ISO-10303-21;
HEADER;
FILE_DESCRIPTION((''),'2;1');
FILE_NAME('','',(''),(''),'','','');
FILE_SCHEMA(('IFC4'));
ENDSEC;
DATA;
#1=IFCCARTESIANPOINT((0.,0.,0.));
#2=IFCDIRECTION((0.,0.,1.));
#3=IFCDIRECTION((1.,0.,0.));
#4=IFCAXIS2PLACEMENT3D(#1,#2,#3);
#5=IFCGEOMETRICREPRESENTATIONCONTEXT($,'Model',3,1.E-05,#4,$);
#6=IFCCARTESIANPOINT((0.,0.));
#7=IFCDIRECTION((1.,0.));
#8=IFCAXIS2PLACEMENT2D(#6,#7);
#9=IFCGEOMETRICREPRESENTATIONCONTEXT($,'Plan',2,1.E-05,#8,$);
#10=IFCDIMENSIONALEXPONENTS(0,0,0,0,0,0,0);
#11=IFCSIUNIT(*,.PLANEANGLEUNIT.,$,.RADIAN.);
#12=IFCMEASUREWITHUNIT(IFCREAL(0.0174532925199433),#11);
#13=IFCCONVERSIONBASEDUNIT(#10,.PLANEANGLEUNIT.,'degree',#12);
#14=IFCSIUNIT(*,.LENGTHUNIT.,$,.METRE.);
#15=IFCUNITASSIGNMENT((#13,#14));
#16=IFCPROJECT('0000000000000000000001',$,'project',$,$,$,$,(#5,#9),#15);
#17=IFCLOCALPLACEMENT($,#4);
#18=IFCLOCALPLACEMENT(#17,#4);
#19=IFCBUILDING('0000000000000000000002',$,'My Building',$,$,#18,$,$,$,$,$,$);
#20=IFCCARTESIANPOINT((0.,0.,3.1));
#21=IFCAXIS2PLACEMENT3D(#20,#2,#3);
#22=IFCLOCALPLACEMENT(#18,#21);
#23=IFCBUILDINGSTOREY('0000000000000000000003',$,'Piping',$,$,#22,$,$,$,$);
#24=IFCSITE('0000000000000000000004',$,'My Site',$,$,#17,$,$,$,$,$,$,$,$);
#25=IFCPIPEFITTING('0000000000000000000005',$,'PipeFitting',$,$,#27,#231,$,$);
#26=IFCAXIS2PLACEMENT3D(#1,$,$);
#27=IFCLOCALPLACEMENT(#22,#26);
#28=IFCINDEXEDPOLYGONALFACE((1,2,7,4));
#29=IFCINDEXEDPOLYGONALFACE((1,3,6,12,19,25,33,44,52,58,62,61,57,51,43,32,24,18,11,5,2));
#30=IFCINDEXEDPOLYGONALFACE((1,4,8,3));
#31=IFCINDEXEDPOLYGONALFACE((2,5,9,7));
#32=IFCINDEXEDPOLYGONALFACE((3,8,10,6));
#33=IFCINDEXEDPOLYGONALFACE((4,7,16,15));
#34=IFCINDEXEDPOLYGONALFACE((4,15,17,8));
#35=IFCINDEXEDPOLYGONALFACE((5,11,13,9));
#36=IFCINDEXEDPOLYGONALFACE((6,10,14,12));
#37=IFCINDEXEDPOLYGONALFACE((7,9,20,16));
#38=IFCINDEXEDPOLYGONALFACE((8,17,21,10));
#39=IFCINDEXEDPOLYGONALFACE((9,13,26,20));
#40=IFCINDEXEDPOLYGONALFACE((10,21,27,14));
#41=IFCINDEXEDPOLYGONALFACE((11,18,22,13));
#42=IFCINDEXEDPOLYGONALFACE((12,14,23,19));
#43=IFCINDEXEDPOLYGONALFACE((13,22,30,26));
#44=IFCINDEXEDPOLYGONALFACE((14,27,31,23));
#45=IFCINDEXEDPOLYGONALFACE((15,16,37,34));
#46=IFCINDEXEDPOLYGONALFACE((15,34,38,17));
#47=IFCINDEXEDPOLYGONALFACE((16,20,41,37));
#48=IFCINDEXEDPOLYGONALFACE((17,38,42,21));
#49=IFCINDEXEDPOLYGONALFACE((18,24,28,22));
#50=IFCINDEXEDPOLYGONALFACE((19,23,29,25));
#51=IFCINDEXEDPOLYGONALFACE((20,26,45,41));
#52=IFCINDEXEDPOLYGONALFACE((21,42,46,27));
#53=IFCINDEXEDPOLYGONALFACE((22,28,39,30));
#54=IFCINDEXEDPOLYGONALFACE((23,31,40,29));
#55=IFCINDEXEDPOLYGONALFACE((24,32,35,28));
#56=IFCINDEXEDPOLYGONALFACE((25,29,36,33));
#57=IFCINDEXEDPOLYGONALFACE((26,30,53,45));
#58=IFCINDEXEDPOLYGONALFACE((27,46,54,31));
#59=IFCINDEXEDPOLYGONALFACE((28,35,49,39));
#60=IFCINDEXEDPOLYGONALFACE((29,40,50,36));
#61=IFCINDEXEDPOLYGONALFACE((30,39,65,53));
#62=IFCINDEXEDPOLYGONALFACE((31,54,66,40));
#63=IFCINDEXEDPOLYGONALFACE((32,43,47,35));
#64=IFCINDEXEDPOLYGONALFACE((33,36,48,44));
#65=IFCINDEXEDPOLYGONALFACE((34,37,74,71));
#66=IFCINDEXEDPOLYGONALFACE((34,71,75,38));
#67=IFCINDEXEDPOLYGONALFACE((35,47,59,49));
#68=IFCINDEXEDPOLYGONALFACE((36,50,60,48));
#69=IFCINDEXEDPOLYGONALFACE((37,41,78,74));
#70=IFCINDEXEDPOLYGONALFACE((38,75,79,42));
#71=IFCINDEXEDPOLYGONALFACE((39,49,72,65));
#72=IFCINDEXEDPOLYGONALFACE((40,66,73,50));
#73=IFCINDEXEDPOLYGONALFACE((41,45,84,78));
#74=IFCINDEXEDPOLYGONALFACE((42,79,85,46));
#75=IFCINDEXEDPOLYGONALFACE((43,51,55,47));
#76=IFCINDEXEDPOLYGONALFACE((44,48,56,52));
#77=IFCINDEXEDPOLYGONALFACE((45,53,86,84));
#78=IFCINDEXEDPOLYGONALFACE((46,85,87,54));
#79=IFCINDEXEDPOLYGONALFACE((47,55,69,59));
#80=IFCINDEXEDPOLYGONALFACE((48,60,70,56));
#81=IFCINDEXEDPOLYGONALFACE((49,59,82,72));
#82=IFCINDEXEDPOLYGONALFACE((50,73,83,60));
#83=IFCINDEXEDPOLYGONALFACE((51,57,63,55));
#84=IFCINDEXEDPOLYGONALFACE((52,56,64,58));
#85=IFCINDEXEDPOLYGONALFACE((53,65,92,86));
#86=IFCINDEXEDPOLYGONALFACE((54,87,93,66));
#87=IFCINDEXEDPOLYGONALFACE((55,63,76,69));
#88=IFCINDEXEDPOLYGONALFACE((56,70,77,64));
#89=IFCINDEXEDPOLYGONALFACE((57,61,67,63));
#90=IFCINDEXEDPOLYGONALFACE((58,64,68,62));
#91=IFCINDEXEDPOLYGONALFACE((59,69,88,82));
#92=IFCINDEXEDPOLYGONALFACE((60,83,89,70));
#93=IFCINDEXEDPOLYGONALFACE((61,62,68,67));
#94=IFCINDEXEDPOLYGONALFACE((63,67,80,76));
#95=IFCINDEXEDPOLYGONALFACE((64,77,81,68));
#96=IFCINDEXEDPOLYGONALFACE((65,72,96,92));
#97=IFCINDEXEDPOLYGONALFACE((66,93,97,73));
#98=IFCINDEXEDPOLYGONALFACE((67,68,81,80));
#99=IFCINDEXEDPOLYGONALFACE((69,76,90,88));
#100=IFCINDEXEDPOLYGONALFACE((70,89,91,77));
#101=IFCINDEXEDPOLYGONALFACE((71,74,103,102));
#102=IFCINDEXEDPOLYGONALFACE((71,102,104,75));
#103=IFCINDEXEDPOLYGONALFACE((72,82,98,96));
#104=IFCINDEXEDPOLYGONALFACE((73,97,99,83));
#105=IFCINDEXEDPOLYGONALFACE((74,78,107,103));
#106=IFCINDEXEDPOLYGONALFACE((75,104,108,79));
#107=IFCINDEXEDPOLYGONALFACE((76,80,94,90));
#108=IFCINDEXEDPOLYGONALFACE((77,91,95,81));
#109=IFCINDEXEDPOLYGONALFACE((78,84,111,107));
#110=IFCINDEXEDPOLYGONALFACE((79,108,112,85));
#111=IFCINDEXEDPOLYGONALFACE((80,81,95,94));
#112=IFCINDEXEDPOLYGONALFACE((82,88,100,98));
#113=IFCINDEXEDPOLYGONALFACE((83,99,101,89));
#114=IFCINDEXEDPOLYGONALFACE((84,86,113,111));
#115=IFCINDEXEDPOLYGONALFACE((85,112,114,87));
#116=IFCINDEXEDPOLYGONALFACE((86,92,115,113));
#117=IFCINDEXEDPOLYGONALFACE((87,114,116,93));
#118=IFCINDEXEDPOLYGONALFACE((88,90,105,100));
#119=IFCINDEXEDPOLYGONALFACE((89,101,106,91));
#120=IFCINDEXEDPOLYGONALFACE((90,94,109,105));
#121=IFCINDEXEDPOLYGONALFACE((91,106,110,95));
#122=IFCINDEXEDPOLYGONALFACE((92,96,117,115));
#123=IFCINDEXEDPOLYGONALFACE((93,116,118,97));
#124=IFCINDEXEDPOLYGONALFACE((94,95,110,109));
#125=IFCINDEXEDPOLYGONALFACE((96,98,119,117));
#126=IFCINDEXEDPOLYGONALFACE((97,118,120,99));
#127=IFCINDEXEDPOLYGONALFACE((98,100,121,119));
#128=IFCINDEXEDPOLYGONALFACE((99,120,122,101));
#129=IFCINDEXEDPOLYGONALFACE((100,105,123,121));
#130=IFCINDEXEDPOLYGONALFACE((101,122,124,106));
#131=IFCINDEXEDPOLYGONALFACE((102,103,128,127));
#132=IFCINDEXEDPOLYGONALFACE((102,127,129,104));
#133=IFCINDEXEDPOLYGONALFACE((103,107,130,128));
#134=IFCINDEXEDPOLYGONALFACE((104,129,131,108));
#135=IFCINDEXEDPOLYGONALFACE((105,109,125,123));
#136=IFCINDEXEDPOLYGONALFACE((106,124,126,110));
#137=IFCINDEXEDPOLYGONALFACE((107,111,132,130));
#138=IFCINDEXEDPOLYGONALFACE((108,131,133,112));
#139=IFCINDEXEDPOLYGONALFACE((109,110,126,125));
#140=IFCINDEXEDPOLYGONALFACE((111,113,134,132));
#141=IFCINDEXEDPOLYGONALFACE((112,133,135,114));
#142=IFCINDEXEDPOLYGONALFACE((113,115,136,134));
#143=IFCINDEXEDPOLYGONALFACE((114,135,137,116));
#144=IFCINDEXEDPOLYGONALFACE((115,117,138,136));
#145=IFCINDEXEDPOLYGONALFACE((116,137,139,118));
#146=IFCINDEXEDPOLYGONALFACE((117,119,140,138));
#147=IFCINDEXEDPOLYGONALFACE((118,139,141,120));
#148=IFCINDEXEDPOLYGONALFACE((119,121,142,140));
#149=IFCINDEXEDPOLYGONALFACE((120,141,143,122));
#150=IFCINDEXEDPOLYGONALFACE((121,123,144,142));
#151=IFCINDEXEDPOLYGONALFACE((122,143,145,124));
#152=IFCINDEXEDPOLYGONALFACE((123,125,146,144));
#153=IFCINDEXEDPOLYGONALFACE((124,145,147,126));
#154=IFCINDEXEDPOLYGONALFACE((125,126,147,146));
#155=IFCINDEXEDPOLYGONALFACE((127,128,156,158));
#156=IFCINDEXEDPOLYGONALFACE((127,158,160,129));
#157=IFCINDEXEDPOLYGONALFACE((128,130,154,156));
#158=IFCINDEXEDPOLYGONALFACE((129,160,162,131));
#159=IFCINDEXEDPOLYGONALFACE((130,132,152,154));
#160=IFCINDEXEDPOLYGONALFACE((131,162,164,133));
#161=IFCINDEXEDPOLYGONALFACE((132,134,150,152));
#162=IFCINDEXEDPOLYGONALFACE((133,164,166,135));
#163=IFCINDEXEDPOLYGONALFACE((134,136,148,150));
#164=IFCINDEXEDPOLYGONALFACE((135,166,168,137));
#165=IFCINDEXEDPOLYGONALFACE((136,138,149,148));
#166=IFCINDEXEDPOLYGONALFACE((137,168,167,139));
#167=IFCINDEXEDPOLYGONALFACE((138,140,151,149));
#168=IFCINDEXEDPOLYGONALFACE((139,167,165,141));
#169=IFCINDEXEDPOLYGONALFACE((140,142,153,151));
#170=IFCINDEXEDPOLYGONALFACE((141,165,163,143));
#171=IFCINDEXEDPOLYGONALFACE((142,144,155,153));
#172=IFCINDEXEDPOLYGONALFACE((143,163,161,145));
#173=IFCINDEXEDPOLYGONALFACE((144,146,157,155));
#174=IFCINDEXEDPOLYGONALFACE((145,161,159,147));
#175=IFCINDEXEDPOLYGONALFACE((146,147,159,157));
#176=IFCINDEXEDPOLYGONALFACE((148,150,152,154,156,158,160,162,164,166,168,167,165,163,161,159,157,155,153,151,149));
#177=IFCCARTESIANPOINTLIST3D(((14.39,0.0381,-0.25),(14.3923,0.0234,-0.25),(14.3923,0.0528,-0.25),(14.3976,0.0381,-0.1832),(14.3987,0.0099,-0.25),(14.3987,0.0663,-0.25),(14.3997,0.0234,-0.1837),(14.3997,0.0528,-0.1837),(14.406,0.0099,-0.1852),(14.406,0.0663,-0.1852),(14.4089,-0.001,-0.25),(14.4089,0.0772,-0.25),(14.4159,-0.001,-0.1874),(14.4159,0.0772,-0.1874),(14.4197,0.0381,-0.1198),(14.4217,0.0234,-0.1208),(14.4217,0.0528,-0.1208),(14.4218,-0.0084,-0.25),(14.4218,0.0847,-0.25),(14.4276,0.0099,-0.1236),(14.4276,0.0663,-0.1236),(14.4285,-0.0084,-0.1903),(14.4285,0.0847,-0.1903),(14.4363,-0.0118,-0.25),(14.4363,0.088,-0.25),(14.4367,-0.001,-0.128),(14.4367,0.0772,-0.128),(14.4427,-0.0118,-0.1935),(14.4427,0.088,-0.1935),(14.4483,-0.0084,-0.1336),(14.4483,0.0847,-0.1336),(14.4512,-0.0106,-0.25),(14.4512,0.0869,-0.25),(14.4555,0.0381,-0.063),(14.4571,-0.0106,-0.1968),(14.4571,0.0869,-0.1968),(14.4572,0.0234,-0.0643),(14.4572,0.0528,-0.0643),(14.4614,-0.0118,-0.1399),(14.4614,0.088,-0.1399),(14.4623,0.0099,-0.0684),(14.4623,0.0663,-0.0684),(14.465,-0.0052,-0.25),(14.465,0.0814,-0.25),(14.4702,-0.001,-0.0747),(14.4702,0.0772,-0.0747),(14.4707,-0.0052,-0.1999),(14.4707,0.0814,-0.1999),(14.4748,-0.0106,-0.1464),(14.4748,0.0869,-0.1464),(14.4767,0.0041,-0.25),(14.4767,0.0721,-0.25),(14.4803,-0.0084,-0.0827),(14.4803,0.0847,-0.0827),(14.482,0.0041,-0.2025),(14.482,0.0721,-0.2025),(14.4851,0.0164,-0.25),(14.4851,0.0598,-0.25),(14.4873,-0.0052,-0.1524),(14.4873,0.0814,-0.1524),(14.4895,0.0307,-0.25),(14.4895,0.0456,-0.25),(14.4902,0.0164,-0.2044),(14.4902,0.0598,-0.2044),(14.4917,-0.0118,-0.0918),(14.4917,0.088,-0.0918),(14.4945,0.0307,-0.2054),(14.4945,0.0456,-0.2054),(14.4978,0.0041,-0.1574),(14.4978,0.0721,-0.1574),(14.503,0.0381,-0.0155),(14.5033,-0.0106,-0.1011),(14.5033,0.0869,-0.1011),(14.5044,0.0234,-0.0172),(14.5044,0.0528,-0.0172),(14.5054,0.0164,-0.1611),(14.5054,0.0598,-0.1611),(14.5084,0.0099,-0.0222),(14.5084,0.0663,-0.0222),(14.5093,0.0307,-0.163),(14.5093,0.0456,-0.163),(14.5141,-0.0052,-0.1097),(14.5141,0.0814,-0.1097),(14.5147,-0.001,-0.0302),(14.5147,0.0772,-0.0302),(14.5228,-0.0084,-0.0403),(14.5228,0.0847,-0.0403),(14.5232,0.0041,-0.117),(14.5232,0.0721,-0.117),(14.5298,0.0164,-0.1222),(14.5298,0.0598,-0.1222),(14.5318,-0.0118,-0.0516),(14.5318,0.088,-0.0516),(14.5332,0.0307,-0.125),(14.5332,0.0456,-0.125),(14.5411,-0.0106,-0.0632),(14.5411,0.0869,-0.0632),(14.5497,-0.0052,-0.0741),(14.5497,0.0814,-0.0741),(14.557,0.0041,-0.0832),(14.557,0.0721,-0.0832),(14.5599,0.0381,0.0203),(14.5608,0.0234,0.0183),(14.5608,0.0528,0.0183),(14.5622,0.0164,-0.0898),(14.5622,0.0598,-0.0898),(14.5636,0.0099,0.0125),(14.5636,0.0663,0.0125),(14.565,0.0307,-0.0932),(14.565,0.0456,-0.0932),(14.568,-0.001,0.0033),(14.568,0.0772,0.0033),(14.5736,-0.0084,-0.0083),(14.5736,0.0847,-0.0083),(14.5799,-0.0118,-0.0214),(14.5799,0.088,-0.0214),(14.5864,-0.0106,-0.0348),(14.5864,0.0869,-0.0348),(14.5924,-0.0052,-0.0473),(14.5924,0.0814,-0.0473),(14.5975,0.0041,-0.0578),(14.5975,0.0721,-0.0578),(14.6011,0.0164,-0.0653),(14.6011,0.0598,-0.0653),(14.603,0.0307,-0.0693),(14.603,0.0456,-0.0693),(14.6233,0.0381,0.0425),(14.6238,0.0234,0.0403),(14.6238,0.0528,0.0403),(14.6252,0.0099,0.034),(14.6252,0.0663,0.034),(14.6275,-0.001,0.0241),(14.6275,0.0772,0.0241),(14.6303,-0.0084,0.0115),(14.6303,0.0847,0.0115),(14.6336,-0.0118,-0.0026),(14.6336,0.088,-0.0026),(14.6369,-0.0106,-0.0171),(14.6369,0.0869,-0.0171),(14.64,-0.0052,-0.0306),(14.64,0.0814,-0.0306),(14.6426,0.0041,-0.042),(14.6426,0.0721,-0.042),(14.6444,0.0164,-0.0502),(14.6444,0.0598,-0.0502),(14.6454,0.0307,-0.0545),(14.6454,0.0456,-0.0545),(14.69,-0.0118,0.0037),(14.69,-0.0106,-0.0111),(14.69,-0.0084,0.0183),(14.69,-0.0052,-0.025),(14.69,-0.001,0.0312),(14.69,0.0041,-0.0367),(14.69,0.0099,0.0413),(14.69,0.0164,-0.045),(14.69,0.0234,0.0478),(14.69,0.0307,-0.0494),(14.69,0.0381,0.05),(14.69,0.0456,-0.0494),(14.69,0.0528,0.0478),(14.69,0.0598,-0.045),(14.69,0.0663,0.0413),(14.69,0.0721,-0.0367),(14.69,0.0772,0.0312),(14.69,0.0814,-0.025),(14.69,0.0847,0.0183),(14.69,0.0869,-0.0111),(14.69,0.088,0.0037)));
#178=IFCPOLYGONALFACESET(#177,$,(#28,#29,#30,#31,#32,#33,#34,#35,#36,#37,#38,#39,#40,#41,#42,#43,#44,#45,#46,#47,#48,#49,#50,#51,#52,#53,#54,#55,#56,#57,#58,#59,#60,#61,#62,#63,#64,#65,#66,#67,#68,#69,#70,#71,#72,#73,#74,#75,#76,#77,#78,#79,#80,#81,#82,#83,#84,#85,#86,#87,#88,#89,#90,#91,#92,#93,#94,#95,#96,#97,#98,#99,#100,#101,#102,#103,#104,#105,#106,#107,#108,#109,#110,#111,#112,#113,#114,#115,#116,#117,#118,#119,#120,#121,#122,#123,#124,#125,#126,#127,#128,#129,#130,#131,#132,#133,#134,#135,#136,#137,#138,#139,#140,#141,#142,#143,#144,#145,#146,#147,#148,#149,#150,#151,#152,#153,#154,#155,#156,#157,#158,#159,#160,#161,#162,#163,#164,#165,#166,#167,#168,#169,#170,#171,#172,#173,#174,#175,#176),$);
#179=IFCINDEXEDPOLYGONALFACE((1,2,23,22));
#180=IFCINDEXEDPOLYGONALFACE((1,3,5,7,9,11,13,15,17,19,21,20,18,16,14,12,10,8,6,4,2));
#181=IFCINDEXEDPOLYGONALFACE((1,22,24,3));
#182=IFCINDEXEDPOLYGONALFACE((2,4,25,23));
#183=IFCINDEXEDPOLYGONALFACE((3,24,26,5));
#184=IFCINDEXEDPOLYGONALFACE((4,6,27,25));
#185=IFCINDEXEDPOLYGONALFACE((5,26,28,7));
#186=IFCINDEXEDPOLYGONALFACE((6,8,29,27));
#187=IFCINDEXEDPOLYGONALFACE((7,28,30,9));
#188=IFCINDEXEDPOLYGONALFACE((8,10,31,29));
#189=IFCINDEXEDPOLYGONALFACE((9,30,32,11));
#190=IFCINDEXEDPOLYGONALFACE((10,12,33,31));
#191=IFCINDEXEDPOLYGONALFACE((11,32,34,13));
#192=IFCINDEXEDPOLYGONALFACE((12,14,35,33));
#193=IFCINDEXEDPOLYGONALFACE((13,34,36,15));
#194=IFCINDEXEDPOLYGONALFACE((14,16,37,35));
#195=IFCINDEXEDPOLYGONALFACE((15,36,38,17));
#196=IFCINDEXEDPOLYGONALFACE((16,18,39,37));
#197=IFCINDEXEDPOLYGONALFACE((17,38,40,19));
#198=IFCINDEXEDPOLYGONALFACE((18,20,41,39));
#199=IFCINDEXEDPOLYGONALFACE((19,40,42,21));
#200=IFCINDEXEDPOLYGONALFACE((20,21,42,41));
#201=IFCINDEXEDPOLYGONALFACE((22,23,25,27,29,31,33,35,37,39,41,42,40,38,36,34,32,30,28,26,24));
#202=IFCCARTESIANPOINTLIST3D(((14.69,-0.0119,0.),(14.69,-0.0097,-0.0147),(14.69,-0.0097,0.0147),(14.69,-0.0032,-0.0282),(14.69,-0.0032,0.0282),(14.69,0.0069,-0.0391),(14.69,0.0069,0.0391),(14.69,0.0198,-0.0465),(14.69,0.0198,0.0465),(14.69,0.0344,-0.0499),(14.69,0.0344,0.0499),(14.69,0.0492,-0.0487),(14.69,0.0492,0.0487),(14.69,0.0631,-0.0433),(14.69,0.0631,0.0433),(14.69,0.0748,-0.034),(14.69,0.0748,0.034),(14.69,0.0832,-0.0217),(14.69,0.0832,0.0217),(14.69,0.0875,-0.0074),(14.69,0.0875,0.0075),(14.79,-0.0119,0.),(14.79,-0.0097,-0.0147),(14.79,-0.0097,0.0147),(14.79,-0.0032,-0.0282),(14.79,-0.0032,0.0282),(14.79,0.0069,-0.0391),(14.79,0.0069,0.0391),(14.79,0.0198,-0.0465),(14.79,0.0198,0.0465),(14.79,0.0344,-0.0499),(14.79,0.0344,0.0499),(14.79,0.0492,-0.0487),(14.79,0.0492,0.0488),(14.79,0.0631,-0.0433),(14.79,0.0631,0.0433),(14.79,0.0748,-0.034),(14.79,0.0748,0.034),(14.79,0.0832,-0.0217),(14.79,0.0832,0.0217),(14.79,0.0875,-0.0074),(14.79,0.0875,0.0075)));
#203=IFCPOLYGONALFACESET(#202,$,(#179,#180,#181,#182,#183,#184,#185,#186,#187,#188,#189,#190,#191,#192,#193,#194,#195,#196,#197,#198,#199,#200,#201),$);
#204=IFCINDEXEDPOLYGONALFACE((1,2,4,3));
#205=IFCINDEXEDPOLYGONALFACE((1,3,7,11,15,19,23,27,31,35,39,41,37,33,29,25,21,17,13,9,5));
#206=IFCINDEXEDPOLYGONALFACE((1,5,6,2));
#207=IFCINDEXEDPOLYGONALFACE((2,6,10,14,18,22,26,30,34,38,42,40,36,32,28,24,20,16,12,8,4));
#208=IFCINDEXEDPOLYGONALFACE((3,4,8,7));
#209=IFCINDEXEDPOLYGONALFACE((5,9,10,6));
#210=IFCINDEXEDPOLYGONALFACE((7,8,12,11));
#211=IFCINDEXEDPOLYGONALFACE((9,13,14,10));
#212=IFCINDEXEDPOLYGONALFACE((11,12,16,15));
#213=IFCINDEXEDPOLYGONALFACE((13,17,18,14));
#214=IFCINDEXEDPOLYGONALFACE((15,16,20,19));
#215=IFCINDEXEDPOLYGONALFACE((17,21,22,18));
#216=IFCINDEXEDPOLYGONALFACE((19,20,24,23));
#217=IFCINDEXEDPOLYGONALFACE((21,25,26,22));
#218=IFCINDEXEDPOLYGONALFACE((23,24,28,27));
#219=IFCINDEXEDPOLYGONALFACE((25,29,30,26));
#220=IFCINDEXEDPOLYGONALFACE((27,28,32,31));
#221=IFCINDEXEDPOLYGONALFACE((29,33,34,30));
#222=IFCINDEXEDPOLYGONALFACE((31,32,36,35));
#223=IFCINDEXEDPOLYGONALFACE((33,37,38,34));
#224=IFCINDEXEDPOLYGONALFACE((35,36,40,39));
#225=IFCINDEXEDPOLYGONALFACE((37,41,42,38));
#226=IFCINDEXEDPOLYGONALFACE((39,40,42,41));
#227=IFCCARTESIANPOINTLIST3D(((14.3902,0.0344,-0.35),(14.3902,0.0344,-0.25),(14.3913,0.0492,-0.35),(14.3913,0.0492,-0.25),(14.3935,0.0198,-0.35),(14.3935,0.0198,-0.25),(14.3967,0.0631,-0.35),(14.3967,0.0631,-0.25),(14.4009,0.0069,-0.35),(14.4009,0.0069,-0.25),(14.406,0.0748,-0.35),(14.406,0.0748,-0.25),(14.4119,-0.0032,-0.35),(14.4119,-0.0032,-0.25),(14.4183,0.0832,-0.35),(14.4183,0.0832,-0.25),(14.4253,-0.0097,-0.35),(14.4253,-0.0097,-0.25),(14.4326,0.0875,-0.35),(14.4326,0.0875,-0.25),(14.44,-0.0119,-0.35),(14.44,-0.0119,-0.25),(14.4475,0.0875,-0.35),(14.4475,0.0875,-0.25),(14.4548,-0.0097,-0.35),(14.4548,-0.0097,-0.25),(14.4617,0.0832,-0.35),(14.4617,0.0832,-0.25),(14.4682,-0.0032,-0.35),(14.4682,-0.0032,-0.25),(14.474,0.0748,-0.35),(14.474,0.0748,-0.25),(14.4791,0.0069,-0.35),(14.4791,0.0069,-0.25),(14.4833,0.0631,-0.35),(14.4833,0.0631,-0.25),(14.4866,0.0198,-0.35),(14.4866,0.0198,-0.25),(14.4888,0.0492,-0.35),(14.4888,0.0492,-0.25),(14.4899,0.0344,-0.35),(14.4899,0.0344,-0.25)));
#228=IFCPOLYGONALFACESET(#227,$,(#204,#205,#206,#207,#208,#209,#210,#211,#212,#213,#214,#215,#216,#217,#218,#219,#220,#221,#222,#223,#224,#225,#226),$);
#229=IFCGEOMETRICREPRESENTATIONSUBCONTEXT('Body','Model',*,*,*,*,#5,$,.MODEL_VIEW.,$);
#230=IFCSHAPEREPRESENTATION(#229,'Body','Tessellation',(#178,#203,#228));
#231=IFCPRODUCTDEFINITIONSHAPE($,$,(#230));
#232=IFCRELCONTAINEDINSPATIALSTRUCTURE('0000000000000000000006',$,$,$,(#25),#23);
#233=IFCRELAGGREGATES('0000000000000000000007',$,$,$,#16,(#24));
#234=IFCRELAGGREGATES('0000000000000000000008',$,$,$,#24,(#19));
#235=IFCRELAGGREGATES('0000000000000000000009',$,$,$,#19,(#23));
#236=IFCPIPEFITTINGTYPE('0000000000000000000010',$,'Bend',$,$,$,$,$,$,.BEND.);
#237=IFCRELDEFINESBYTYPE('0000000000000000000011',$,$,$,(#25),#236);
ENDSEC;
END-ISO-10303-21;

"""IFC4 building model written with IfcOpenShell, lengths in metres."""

from ifc_helpers import new_model, entity, si_unit, converted_unit, frame, origin_with_axes, origin_2d_with_axis, place, context, subcontext, project, spatial, circle, extrude, source, transform, mapped, type_object, type_shapes, element, save


model = new_model("IFC4")

# Units and contexts
model_context = context("Model", 3, precision=1e-05, world=origin_with_axes())
plan_context = context("Plan", 2, precision=1e-05, world=origin_2d_with_axis())
body_context = subcontext(model_context, "Body", "Model", "MODEL_VIEW")
ifc_project = project(units=[converted_unit("PLANEANGLEUNIT", "degree", entity("IfcReal", 0.0174532925199433), si_unit("PLANEANGLEUNIT", "RADIAN"), dimensions=[0, 0, 0, 0, 0, 0, 0]), si_unit("LENGTHUNIT", "METRE")], contexts=[model_context, plan_context])

# Site, building, storey
site_placement = place(None, origin_with_axes())
site = spatial("IfcSite", under=ifc_project, at=site_placement, Name="My Site")
building_placement = place(site_placement, origin_with_axes())
building = spatial("IfcBuilding", under=site, at=building_placement, Name="My Building")
storey_placement = place(building_placement, frame((0.0, 0.0, 3.1), z_axis=(0.0, 0.0, 1.0), x_axis=(1.0, 0.0, 0.0)))
storey = spatial("IfcBuildingStorey", under=building, at=storey_placement, Name="Piping")

# Pipe fitting
pipe_fitting_type_1 = type_object("IfcPipeFittingType", Name="Bend", PredefinedType="BEND")
shared_shape_1 = source(origin_with_axes(), body_context, "Body", "SolidModel", [
    entity("IfcSweptDiskSolid", entity("IfcIndexedPolyCurve", entity("IfcCartesianPointList3D", [[0.0, 0.0, 0.1], [0.0, -0.0732, 0.2768], [0.0, -0.25, 0.35]]), [entity("IfcArcIndex", [1, 2, 3])]), 0.05),
    extrude(circle(Radius=0.05), origin_with_axes(), (0.0, 0.0, 1.0), 0.1),
    extrude(circle(Radius=0.05), frame((0.0, -0.25, 0.35), z_axis=(0.0, -1.0, 0.000022), x_axis=(1.0, 0.0, 0.0)), (0.0, 0.0, 1.0), 0.1),
])
type_shapes(pipe_fitting_type_1, [shared_shape_1])
for number, where, z_axis, x_axis, name in (
    (1, (14.79, 0.0381, 0.0), (-1.0, 0.0, -0.000022), (0.0, -1.0, 0.0), "PipeFitting"),
):
    element("IfcPipeFitting", number, at=place(storey_placement, frame(where, z_axis=z_axis, x_axis=x_axis)), inside=storey, type_object=pipe_fitting_type_1, Name=name, context=body_context, shape_type="MappedRepresentation", body=[
        mapped(shared_shape_1, transform((0.0, 0.0, 0.0), x_axis=(1.0, 0.0, 0.0), y_axis=(0.0, 1.0, 0.0), z_axis=(0.0, 0.0, 1.0), scale=1.0)),
    ])

save(model, "model.ifc")
